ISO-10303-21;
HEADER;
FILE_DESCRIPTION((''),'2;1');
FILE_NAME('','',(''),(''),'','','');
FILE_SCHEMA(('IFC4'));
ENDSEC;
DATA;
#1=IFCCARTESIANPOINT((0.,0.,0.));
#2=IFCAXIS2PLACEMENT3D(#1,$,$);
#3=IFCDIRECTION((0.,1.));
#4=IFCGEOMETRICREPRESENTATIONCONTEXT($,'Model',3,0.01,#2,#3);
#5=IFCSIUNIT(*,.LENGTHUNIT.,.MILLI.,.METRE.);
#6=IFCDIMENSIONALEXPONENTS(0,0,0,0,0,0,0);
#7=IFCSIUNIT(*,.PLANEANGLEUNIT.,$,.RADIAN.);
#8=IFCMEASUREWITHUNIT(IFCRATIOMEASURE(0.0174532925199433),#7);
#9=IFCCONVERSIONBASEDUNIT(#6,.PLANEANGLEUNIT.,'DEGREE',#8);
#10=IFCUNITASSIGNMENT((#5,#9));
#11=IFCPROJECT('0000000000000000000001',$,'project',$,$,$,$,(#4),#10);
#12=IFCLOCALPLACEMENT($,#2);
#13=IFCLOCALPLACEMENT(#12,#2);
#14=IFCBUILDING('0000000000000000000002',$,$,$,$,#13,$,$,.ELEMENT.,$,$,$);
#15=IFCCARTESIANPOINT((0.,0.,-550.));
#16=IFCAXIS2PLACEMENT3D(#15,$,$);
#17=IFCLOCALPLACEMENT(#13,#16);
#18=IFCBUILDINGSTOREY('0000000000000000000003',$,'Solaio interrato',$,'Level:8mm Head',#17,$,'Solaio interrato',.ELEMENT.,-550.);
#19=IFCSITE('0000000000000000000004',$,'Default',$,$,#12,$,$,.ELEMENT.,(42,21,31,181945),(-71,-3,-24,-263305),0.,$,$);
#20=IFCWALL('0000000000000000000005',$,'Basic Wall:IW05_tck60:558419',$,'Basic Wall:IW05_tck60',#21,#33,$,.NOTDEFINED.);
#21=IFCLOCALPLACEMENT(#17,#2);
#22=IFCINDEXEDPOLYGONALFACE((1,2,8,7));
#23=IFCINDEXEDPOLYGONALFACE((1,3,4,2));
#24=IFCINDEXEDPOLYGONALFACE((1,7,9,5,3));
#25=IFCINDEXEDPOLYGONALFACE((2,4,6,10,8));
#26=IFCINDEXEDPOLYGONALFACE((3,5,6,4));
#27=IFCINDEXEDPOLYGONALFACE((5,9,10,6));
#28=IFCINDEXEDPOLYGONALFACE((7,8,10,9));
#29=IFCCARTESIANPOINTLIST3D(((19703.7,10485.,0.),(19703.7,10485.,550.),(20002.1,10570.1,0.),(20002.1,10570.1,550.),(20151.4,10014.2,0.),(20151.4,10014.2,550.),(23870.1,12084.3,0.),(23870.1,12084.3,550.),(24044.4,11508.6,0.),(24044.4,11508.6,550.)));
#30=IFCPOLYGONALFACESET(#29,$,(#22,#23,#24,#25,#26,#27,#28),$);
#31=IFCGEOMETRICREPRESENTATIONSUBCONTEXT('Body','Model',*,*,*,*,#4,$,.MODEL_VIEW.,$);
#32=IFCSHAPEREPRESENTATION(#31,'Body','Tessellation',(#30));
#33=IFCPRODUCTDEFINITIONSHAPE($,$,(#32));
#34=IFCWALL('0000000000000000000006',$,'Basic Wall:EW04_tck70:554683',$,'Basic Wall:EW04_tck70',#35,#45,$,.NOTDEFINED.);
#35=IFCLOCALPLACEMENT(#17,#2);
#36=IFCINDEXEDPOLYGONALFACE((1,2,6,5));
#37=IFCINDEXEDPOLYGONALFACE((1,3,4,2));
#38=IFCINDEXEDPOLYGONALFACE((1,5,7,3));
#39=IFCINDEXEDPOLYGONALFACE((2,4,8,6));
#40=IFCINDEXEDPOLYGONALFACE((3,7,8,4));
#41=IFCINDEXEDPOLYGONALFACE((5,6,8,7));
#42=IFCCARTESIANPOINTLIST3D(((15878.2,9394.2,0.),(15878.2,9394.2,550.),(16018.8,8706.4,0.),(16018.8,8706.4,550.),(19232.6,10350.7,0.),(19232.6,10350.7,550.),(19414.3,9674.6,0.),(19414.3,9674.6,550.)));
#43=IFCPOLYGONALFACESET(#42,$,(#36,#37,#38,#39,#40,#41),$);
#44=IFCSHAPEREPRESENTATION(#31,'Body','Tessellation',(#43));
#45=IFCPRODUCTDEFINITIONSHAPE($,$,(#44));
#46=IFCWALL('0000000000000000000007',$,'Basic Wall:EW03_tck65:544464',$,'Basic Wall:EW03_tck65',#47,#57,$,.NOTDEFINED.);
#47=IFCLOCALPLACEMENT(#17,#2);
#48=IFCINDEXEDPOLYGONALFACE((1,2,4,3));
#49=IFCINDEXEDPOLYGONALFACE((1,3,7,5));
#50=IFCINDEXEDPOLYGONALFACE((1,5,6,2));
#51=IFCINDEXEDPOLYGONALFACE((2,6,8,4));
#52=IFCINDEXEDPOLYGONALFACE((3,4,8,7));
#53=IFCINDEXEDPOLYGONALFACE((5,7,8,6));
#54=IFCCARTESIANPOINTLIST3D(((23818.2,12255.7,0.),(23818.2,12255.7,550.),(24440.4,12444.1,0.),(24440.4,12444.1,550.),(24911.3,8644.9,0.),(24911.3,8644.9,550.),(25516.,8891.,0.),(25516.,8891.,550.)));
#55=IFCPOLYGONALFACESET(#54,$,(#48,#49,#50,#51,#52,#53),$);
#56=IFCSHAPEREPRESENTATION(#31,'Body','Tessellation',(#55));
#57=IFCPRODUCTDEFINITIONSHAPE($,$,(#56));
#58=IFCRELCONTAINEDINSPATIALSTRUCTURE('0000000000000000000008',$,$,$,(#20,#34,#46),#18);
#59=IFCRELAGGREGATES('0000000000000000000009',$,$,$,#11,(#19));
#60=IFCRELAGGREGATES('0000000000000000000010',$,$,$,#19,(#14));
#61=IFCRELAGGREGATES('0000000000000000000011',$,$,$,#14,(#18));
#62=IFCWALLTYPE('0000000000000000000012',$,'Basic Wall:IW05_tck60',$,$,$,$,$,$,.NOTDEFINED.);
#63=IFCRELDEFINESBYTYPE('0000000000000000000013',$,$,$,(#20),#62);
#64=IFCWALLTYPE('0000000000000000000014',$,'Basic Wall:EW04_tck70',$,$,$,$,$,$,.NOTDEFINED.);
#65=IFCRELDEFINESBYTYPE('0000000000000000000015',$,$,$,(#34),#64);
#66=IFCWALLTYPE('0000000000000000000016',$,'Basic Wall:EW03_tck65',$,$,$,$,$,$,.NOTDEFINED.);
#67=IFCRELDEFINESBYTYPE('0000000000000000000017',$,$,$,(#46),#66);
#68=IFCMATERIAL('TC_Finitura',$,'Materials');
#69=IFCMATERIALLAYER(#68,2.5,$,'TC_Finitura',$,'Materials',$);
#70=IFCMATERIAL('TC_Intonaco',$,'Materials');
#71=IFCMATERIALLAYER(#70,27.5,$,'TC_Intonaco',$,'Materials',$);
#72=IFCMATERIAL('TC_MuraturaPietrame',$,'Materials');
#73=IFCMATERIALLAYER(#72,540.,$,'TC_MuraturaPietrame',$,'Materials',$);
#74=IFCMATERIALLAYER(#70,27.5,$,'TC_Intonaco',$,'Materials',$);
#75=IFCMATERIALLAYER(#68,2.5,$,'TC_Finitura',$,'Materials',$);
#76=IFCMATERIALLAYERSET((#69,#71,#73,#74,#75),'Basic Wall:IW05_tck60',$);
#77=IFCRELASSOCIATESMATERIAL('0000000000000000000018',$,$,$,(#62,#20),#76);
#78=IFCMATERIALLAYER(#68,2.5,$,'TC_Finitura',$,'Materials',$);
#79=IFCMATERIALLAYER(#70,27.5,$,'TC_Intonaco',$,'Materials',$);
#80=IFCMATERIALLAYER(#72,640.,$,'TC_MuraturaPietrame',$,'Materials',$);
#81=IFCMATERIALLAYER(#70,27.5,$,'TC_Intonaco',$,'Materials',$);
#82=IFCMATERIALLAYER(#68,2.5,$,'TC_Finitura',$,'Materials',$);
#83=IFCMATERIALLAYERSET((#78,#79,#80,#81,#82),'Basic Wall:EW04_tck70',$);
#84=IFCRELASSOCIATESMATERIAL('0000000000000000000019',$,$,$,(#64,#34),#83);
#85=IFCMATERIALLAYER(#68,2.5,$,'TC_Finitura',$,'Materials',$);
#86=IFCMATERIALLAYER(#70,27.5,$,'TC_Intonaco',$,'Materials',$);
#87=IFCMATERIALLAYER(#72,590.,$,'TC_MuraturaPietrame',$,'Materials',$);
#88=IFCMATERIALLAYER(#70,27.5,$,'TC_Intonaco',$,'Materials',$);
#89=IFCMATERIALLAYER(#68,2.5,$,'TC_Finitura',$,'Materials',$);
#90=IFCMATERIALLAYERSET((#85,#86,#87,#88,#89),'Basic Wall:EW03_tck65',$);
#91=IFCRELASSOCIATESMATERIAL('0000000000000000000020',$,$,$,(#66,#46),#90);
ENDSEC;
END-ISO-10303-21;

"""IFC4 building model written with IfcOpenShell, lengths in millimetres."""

from ifc_helpers import new_model, entity, si_unit, converted_unit, direction, frame, origin, place, context, subcontext, project, spatial, polyline, outline, extrude, clip, halfspace, material, layer, layer_set, layer_usage, type_object, element, save


model = new_model("IFC4")

# Units and contexts
model_context = context("Model", 3, precision=0.01, world=origin(), true_north=direction((0.0, 1.0)))
body_context = subcontext(model_context, "Body", "Model", "MODEL_VIEW")
ifc_project = project(units=[si_unit("LENGTHUNIT", "METRE", prefix="MILLI"), converted_unit("PLANEANGLEUNIT", "DEGREE", entity("IfcRatioMeasure", 0.0174532925199433), si_unit("PLANEANGLEUNIT", "RADIAN"), dimensions=[0, 0, 0, 0, 0, 0, 0])], contexts=[model_context])

# Site, building, storey
site_placement = place(None, origin())
site = spatial("IfcSite", under=ifc_project, at=site_placement, Name="Default", CompositionType="ELEMENT", RefLatitude=(42, 21, 31, 181945), RefLongitude=(-71, -3, -24, -263305), RefElevation=0.0)
building_placement = place(site_placement, origin())
building = spatial("IfcBuilding", under=site, at=building_placement, CompositionType="ELEMENT")
storey_placement = place(building_placement, frame((0.0, 0.0, -550.0)))
storey = spatial("IfcBuildingStorey", under=building, at=storey_placement, Name="Solaio interrato", ObjectType="Level:8mm Head", LongName="Solaio interrato", CompositionType="ELEMENT", Elevation=-550.0)

# Shared definitions
ifc_material_1 = material(Name="TC_Finitura", Category="Materials")
ifc_material_2 = material(Name="TC_Intonaco", Category="Materials")
ifc_material_3 = material(Name="TC_MuraturaPietrame", Category="Materials")

# Walls
ifc_layer_1 = layer(ifc_material_1, 2.5, Name="TC_Finitura", Category="Materials")
ifc_layer_2 = layer(ifc_material_2, 27.5, Name="TC_Intonaco", Category="Materials")
ifc_layer_3 = layer(ifc_material_3, 540.0, Name="TC_MuraturaPietrame", Category="Materials")
ifc_layer_4 = layer(ifc_material_2, 27.5, Name="TC_Intonaco", Category="Materials")
ifc_layer_5 = layer(ifc_material_1, 2.5, Name="TC_Finitura", Category="Materials")
ifc_layer_set_1 = layer_set([ifc_layer_1, ifc_layer_2, ifc_layer_3, ifc_layer_4, ifc_layer_5], Name="Basic Wall:IW05_tck60")
ifc_layer_usage_1 = layer_usage(ifc_layer_set_1, "AXIS2", "NEGATIVE", 300.0)
wall_type_1 = type_object("IfcWallType", Name="Basic Wall:IW05_tck60", PredefinedType="NOTDEFINED", material=ifc_layer_set_1)
wall_1_placement = place(storey_placement, frame((19811.2, 10204.9, 0.0), z_axis=(0.0, 0.0, 1.0), x_axis=(0.93358, 0.358368, 0.0)))
element("IfcWall", 1, at=wall_1_placement, inside=storey, type_object=wall_type_1, material=ifc_layer_usage_1, Name="Basic Wall:IW05_tck60:558419", ObjectType="Basic Wall:IW05_tck60", PredefinedType="NOTDEFINED", context=body_context, shape_type="Clipping", body=[
    clip(extrude(outline(polyline([(4419.3, -300.0), (4462.9, 300.0), (0.0, 300.0), (309.1, 272.5), (249.3, -300.0), (4419.3, -300.0)])), origin(), (0.0, 0.0, 1.0), 550.0), halfspace(origin(), True)),
])
ifc_layer_6 = layer(ifc_material_1, 2.5, Name="TC_Finitura", Category="Materials")
ifc_layer_7 = layer(ifc_material_2, 27.5, Name="TC_Intonaco", Category="Materials")
ifc_layer_8 = layer(ifc_material_3, 640.0, Name="TC_MuraturaPietrame", Category="Materials")
ifc_layer_9 = layer(ifc_material_2, 27.5, Name="TC_Intonaco", Category="Materials")
ifc_layer_10 = layer(ifc_material_1, 2.5, Name="TC_Finitura", Category="Materials")
ifc_layer_set_2 = layer_set([ifc_layer_6, ifc_layer_7, ifc_layer_8, ifc_layer_9, ifc_layer_10], Name="Basic Wall:EW04_tck70")
ifc_layer_usage_2 = layer_usage(ifc_layer_set_2, "AXIS2", "POSITIVE", -350.0)
wall_type_2 = type_object("IfcWallType", Name="Basic Wall:EW04_tck70", PredefinedType="NOTDEFINED", material=ifc_layer_set_2)
wall_2_placement = place(storey_placement, frame((19328.6, 10014.1, 0.0), z_axis=(0.0, 0.0, 1.0), x_axis=(-0.961671, -0.274205, 0.0)))
element("IfcWall", 2, at=wall_2_placement, inside=storey, type_object=wall_type_2, material=ifc_layer_usage_2, Name="Basic Wall:EW04_tck70:554683", ObjectType="Basic Wall:EW04_tck70", PredefinedType="NOTDEFINED", context=body_context, shape_type="Clipping", body=[
    clip(extrude(outline(polyline([(3488.2, -350.0), (3541.5, 350.0), (10.7, 350.0), (0.0, -350.0), (3488.2, -350.0)])), origin(), (0.0, 0.0, 1.0), 550.0), halfspace(origin(), True)),
])
ifc_layer_11 = layer(ifc_material_1, 2.5, Name="TC_Finitura", Category="Materials")
ifc_layer_12 = layer(ifc_material_2, 27.5, Name="TC_Intonaco", Category="Materials")
ifc_layer_13 = layer(ifc_material_3, 590.0, Name="TC_MuraturaPietrame", Category="Materials")
ifc_layer_14 = layer(ifc_material_2, 27.5, Name="TC_Intonaco", Category="Materials")
ifc_layer_15 = layer(ifc_material_1, 2.5, Name="TC_Finitura", Category="Materials")
ifc_layer_set_3 = layer_set([ifc_layer_11, ifc_layer_12, ifc_layer_13, ifc_layer_14, ifc_layer_15], Name="Basic Wall:EW03_tck65")
ifc_layer_usage_3 = layer_usage(ifc_layer_set_3, "AXIS2", "NEGATIVE", 325.0)
wall_type_3 = type_object("IfcWallType", Name="Basic Wall:EW03_tck65", PredefinedType="NOTDEFINED", material=ifc_layer_set_3)
wall_3_placement = place(storey_placement, frame((24129.3, 12349.9, 0.0), z_axis=(0.0, 0.0, 1.0), x_axis=(0.28974, -0.957105, 0.0)))
element("IfcWall", 3, at=wall_3_placement, inside=storey, type_object=wall_type_3, material=ifc_layer_usage_3, Name="Basic Wall:EW03_tck65:544464", ObjectType="Basic Wall:EW03_tck65", PredefinedType="NOTDEFINED", context=body_context, shape_type="Clipping", body=[
    clip(extrude(outline(polyline([(3772.7, -325.0), (3712.3, 325.0), (0.0, 325.0), (0.0, -325.0), (179.1, -325.0), (780.7, -325.0), (3772.7, -325.0)])), origin(), (0.0, 0.0, 1.0), 550.0), halfspace(origin(), True)),
])

save(model, "model.ifc")
